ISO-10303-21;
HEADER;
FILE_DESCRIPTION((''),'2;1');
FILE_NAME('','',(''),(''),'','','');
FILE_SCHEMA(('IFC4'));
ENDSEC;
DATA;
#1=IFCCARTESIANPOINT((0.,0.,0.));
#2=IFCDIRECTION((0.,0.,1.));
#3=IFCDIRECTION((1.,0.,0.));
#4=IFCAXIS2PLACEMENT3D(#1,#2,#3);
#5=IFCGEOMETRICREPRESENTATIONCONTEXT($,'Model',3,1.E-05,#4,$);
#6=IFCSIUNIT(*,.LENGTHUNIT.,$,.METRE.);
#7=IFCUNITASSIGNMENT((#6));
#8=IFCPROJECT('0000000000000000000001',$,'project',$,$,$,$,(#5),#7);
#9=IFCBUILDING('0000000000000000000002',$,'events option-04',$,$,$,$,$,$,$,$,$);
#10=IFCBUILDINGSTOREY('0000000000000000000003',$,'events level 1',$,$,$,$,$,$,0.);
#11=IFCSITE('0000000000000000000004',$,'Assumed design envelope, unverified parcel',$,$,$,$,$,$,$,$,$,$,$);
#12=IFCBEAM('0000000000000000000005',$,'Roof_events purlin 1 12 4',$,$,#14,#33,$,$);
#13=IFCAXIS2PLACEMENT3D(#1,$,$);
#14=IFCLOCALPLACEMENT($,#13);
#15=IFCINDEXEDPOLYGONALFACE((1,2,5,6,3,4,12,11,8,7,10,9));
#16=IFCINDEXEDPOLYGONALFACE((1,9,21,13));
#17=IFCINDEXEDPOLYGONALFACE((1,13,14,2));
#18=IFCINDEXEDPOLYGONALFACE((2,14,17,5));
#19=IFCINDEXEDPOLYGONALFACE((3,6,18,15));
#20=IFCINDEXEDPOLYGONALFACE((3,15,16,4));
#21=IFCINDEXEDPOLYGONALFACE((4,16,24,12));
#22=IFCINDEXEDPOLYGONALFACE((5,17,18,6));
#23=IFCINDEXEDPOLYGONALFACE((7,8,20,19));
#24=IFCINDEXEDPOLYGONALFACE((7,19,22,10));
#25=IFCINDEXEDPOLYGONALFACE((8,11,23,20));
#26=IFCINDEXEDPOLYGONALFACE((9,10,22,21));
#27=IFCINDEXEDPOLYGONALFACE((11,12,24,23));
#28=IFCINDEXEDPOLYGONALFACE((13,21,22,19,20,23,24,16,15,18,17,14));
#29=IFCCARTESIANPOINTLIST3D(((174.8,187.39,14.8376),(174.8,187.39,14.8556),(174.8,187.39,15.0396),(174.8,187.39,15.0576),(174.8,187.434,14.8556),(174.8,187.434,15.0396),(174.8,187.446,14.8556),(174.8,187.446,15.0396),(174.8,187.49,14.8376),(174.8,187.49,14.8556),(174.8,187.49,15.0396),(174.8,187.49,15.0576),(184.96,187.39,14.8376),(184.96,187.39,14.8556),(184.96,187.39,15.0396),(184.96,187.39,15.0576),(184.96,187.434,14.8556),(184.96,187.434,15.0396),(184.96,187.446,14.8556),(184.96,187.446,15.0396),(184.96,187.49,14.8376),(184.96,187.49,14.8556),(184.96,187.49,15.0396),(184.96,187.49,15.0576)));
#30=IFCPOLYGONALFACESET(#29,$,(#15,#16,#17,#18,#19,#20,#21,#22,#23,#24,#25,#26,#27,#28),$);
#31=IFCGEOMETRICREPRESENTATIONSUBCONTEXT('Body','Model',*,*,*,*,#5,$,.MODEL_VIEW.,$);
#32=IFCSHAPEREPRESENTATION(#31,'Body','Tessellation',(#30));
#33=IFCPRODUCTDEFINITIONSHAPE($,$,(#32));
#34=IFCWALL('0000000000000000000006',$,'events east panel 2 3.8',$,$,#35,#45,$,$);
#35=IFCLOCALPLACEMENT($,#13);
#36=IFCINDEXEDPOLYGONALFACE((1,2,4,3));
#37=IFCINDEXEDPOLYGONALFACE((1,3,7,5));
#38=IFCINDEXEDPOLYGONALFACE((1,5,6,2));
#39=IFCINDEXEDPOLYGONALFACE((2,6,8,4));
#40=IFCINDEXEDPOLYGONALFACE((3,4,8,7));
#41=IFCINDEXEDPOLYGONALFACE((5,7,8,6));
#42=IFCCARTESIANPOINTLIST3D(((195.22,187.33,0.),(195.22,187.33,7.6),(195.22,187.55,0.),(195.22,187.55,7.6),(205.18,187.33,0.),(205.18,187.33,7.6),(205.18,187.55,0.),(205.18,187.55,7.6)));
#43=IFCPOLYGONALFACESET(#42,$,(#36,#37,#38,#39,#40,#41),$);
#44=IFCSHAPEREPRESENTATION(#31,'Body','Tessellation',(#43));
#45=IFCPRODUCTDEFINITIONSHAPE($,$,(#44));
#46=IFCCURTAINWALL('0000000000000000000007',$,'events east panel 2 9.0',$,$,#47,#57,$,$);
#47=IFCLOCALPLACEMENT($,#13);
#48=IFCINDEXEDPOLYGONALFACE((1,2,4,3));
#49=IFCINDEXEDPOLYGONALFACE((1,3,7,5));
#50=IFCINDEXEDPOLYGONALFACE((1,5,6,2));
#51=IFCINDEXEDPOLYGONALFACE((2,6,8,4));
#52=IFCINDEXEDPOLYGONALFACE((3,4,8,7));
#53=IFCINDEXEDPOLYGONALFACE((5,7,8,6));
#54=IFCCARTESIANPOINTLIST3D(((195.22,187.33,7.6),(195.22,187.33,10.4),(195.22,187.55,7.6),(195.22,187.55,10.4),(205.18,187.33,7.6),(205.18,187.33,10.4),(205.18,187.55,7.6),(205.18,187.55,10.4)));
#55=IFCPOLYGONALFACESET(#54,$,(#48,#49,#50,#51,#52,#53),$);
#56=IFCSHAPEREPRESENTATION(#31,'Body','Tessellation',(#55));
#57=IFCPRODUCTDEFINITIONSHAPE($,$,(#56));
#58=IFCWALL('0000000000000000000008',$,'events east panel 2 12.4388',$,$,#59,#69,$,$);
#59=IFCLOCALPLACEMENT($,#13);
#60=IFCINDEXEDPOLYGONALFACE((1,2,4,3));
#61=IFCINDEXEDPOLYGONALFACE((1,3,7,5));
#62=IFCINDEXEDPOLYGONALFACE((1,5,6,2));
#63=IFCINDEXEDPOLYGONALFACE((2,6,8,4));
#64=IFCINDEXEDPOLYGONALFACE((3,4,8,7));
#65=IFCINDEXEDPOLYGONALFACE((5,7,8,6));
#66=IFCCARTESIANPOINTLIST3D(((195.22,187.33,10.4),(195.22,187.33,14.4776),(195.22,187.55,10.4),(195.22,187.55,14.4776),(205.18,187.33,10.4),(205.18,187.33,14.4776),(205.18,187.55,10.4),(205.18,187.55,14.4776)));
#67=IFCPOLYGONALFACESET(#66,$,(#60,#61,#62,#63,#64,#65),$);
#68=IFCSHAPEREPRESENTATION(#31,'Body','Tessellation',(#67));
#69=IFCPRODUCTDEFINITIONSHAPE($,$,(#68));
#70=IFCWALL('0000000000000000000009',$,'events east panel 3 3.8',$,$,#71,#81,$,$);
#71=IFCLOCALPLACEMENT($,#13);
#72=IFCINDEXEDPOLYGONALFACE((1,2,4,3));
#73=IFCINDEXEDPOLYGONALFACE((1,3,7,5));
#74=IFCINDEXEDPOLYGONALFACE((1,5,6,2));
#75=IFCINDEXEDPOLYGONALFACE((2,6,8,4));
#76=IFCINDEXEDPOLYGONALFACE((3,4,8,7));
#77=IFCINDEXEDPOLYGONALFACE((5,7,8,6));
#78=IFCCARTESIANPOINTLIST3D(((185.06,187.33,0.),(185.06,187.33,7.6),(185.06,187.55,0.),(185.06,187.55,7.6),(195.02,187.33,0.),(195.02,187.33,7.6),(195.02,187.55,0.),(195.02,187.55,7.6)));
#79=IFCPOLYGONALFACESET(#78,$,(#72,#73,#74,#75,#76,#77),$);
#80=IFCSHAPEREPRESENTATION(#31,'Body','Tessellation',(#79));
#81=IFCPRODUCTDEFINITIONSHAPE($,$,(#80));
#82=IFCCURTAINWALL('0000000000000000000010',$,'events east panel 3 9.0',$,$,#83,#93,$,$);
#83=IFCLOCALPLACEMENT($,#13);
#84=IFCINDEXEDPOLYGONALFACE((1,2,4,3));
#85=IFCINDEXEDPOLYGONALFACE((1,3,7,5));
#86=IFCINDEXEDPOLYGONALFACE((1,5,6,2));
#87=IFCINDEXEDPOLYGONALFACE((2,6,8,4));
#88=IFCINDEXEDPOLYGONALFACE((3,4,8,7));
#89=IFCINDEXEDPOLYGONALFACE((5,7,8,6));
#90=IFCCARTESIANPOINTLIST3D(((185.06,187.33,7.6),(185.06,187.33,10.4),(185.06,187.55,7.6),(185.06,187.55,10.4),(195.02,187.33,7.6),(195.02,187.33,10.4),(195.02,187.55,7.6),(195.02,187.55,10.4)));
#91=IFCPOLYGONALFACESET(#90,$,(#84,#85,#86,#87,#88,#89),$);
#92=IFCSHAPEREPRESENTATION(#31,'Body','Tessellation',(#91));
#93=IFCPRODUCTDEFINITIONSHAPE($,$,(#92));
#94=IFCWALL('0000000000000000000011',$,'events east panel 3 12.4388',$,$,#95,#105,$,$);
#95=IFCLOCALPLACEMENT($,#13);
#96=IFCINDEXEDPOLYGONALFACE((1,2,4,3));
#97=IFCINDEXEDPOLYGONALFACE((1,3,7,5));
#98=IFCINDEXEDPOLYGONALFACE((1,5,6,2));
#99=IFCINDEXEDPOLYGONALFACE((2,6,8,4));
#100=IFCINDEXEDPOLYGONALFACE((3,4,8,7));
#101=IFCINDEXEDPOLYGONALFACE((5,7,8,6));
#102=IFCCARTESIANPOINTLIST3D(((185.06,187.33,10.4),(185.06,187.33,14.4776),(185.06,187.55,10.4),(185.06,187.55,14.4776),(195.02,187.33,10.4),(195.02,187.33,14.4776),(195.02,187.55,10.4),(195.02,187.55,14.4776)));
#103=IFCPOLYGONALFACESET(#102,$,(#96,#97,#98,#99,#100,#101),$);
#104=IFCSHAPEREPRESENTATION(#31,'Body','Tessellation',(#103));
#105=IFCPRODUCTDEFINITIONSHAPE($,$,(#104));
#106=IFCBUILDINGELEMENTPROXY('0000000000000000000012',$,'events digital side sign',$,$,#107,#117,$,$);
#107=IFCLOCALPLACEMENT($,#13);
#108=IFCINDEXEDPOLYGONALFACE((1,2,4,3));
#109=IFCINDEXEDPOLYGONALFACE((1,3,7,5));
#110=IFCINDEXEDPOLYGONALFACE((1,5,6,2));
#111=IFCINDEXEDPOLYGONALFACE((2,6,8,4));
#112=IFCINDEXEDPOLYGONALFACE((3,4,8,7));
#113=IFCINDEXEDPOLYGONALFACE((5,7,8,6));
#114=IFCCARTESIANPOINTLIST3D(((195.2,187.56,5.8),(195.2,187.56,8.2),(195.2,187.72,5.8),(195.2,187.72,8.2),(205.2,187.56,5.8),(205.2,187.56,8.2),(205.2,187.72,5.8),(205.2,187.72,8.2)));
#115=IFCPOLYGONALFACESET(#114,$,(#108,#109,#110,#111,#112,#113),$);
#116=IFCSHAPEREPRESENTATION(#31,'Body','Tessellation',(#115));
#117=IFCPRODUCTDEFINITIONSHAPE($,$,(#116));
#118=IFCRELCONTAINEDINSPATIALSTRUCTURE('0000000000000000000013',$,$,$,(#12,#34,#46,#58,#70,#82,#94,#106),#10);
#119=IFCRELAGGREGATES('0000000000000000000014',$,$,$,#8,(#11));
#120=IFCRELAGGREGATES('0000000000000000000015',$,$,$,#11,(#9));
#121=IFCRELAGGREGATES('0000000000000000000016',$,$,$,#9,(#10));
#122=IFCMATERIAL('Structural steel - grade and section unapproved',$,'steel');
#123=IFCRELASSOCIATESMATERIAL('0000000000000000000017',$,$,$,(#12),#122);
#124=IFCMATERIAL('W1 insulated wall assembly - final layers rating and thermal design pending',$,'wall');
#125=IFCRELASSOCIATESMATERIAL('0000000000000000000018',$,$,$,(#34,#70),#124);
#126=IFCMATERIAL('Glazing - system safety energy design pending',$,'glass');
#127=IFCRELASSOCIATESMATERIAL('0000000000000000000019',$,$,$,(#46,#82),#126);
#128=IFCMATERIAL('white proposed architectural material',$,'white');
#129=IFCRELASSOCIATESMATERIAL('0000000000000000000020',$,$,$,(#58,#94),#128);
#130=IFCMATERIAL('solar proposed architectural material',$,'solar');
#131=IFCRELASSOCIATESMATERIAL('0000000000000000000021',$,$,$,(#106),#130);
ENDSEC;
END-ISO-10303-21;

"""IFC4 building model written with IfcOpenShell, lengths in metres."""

from ifc_helpers import new_model, si_unit, frame, origin_with_axes, place, context, subcontext, project, spatial, rectangle, i_section, extrude, material, element, save


model = new_model("IFC4")

# Units and contexts
model_context = context("Model", 3, precision=1e-05, world=origin_with_axes())
body_context = subcontext(model_context, "Body", "Model", "MODEL_VIEW")
ifc_project = project(units=[si_unit("LENGTHUNIT", "METRE")], contexts=[model_context])

# Site, building, storey
site = spatial("IfcSite", under=ifc_project, Name="Assumed design envelope, unverified parcel")
building = spatial("IfcBuilding", under=site, Name="events option-04")
storey = spatial("IfcBuildingStorey", under=building, Name="events level 1", Elevation=0.0)

# Shared definitions
ifc_material_1 = material(Name="Structural steel - grade and section unapproved", Category="steel")

# Beam
beam_1_placement = place(None, frame((184.96, 187.44, 14.9476), z_axis=(-1.0, 0.0, 0.0), x_axis=(0.0, -1.0, 0.0)))
element("IfcBeam", 1, at=beam_1_placement, inside=storey, material=ifc_material_1, Name="Roof_events purlin 1 12 4", context=body_context, shape_type="SweptSolid", body=[
    extrude(i_section(OverallWidth=0.1, OverallDepth=0.22, WebThickness=0.012, FlangeThickness=0.018, FilletRadius=0.0), origin_with_axes(), (0.0, 0.0, 1.0), 10.16),
])

# Wall
ifc_material_2 = material(Name="W1 insulated wall assembly - final layers rating and thermal design pending", Category="wall")
wall_1_placement = place(None, frame((200.2, 187.44, 0.0), z_axis=(0.0, 0.0, 1.0), x_axis=(0.0, 1.0, 0.0)))
element("IfcWall", 2, at=wall_1_placement, inside=storey, material=ifc_material_2, Name="events east panel 2 3.8", context=body_context, shape_type="SweptSolid", body=[
    extrude(rectangle(XDim=0.22, YDim=9.96), origin_with_axes(), (0.0, 0.0, 1.0), 7.6),
])

# Curtain wall
ifc_material_3 = material(Name="Glazing - system safety energy design pending", Category="glass")
curtain_wall_1_placement = place(None, frame((200.2, 187.44, 7.6), z_axis=(0.0, 0.0, 1.0), x_axis=(0.0, 1.0, 0.0)))
element("IfcCurtainWall", 3, at=curtain_wall_1_placement, inside=storey, material=ifc_material_3, Name="events east panel 2 9.0", context=body_context, shape_type="SweptSolid", body=[
    extrude(rectangle(XDim=0.22, YDim=9.96), origin_with_axes(), (0.0, 0.0, 1.0), 2.8),
])

# Walls
ifc_material_4 = material(Name="white proposed architectural material", Category="white")
wall_2_placement = place(None, frame((200.2, 187.44, 10.4), z_axis=(0.0, 0.0, 1.0), x_axis=(0.0, 1.0, 0.0)))
element("IfcWall", 4, at=wall_2_placement, inside=storey, material=ifc_material_4, Name="events east panel 2 12.4388", context=body_context, shape_type="SweptSolid", body=[
    extrude(rectangle(XDim=0.22, YDim=9.96), origin_with_axes(), (0.0, 0.0, 1.0), 4.0776),
])
wall_3_placement = place(None, frame((190.04, 187.44, 0.0), z_axis=(0.0, 0.0, 1.0), x_axis=(0.0, 1.0, 0.0)))
element("IfcWall", 5, at=wall_3_placement, inside=storey, material=ifc_material_2, Name="events east panel 3 3.8", context=body_context, shape_type="SweptSolid", body=[
    extrude(rectangle(XDim=0.22, YDim=9.96), origin_with_axes(), (0.0, 0.0, 1.0), 7.6),
])

# Curtain wall
curtain_wall_2_placement = place(None, frame((190.04, 187.44, 7.6), z_axis=(0.0, 0.0, 1.0), x_axis=(0.0, 1.0, 0.0)))
element("IfcCurtainWall", 6, at=curtain_wall_2_placement, inside=storey, material=ifc_material_3, Name="events east panel 3 9.0", context=body_context, shape_type="SweptSolid", body=[
    extrude(rectangle(XDim=0.22, YDim=9.96), origin_with_axes(), (0.0, 0.0, 1.0), 2.8),
])

# Wall
wall_4_placement = place(None, frame((190.04, 187.44, 10.4), z_axis=(0.0, 0.0, 1.0), x_axis=(0.0, 1.0, 0.0)))
element("IfcWall", 7, at=wall_4_placement, inside=storey, material=ifc_material_4, Name="events east panel 3 12.4388", context=body_context, shape_type="SweptSolid", body=[
    extrude(rectangle(XDim=0.22, YDim=9.96), origin_with_axes(), (0.0, 0.0, 1.0), 4.0776),
])

# Building element proxy
ifc_material_5 = material(Name="solar proposed architectural material", Category="solar")
proxy_placement = place(None, frame((200.2, 187.64, 5.8), z_axis=(0.0, 0.0, 1.0), x_axis=(0.0, 1.0, 0.0)))
element("IfcBuildingElementProxy", 8, at=proxy_placement, inside=storey, material=ifc_material_5, Name="events digital side sign", context=body_context, shape_type="SweptSolid", body=[
    extrude(rectangle(XDim=0.16, YDim=10.0), origin_with_axes(), (0.0, 0.0, 1.0), 2.4),
])

save(model, "model.ifc")
